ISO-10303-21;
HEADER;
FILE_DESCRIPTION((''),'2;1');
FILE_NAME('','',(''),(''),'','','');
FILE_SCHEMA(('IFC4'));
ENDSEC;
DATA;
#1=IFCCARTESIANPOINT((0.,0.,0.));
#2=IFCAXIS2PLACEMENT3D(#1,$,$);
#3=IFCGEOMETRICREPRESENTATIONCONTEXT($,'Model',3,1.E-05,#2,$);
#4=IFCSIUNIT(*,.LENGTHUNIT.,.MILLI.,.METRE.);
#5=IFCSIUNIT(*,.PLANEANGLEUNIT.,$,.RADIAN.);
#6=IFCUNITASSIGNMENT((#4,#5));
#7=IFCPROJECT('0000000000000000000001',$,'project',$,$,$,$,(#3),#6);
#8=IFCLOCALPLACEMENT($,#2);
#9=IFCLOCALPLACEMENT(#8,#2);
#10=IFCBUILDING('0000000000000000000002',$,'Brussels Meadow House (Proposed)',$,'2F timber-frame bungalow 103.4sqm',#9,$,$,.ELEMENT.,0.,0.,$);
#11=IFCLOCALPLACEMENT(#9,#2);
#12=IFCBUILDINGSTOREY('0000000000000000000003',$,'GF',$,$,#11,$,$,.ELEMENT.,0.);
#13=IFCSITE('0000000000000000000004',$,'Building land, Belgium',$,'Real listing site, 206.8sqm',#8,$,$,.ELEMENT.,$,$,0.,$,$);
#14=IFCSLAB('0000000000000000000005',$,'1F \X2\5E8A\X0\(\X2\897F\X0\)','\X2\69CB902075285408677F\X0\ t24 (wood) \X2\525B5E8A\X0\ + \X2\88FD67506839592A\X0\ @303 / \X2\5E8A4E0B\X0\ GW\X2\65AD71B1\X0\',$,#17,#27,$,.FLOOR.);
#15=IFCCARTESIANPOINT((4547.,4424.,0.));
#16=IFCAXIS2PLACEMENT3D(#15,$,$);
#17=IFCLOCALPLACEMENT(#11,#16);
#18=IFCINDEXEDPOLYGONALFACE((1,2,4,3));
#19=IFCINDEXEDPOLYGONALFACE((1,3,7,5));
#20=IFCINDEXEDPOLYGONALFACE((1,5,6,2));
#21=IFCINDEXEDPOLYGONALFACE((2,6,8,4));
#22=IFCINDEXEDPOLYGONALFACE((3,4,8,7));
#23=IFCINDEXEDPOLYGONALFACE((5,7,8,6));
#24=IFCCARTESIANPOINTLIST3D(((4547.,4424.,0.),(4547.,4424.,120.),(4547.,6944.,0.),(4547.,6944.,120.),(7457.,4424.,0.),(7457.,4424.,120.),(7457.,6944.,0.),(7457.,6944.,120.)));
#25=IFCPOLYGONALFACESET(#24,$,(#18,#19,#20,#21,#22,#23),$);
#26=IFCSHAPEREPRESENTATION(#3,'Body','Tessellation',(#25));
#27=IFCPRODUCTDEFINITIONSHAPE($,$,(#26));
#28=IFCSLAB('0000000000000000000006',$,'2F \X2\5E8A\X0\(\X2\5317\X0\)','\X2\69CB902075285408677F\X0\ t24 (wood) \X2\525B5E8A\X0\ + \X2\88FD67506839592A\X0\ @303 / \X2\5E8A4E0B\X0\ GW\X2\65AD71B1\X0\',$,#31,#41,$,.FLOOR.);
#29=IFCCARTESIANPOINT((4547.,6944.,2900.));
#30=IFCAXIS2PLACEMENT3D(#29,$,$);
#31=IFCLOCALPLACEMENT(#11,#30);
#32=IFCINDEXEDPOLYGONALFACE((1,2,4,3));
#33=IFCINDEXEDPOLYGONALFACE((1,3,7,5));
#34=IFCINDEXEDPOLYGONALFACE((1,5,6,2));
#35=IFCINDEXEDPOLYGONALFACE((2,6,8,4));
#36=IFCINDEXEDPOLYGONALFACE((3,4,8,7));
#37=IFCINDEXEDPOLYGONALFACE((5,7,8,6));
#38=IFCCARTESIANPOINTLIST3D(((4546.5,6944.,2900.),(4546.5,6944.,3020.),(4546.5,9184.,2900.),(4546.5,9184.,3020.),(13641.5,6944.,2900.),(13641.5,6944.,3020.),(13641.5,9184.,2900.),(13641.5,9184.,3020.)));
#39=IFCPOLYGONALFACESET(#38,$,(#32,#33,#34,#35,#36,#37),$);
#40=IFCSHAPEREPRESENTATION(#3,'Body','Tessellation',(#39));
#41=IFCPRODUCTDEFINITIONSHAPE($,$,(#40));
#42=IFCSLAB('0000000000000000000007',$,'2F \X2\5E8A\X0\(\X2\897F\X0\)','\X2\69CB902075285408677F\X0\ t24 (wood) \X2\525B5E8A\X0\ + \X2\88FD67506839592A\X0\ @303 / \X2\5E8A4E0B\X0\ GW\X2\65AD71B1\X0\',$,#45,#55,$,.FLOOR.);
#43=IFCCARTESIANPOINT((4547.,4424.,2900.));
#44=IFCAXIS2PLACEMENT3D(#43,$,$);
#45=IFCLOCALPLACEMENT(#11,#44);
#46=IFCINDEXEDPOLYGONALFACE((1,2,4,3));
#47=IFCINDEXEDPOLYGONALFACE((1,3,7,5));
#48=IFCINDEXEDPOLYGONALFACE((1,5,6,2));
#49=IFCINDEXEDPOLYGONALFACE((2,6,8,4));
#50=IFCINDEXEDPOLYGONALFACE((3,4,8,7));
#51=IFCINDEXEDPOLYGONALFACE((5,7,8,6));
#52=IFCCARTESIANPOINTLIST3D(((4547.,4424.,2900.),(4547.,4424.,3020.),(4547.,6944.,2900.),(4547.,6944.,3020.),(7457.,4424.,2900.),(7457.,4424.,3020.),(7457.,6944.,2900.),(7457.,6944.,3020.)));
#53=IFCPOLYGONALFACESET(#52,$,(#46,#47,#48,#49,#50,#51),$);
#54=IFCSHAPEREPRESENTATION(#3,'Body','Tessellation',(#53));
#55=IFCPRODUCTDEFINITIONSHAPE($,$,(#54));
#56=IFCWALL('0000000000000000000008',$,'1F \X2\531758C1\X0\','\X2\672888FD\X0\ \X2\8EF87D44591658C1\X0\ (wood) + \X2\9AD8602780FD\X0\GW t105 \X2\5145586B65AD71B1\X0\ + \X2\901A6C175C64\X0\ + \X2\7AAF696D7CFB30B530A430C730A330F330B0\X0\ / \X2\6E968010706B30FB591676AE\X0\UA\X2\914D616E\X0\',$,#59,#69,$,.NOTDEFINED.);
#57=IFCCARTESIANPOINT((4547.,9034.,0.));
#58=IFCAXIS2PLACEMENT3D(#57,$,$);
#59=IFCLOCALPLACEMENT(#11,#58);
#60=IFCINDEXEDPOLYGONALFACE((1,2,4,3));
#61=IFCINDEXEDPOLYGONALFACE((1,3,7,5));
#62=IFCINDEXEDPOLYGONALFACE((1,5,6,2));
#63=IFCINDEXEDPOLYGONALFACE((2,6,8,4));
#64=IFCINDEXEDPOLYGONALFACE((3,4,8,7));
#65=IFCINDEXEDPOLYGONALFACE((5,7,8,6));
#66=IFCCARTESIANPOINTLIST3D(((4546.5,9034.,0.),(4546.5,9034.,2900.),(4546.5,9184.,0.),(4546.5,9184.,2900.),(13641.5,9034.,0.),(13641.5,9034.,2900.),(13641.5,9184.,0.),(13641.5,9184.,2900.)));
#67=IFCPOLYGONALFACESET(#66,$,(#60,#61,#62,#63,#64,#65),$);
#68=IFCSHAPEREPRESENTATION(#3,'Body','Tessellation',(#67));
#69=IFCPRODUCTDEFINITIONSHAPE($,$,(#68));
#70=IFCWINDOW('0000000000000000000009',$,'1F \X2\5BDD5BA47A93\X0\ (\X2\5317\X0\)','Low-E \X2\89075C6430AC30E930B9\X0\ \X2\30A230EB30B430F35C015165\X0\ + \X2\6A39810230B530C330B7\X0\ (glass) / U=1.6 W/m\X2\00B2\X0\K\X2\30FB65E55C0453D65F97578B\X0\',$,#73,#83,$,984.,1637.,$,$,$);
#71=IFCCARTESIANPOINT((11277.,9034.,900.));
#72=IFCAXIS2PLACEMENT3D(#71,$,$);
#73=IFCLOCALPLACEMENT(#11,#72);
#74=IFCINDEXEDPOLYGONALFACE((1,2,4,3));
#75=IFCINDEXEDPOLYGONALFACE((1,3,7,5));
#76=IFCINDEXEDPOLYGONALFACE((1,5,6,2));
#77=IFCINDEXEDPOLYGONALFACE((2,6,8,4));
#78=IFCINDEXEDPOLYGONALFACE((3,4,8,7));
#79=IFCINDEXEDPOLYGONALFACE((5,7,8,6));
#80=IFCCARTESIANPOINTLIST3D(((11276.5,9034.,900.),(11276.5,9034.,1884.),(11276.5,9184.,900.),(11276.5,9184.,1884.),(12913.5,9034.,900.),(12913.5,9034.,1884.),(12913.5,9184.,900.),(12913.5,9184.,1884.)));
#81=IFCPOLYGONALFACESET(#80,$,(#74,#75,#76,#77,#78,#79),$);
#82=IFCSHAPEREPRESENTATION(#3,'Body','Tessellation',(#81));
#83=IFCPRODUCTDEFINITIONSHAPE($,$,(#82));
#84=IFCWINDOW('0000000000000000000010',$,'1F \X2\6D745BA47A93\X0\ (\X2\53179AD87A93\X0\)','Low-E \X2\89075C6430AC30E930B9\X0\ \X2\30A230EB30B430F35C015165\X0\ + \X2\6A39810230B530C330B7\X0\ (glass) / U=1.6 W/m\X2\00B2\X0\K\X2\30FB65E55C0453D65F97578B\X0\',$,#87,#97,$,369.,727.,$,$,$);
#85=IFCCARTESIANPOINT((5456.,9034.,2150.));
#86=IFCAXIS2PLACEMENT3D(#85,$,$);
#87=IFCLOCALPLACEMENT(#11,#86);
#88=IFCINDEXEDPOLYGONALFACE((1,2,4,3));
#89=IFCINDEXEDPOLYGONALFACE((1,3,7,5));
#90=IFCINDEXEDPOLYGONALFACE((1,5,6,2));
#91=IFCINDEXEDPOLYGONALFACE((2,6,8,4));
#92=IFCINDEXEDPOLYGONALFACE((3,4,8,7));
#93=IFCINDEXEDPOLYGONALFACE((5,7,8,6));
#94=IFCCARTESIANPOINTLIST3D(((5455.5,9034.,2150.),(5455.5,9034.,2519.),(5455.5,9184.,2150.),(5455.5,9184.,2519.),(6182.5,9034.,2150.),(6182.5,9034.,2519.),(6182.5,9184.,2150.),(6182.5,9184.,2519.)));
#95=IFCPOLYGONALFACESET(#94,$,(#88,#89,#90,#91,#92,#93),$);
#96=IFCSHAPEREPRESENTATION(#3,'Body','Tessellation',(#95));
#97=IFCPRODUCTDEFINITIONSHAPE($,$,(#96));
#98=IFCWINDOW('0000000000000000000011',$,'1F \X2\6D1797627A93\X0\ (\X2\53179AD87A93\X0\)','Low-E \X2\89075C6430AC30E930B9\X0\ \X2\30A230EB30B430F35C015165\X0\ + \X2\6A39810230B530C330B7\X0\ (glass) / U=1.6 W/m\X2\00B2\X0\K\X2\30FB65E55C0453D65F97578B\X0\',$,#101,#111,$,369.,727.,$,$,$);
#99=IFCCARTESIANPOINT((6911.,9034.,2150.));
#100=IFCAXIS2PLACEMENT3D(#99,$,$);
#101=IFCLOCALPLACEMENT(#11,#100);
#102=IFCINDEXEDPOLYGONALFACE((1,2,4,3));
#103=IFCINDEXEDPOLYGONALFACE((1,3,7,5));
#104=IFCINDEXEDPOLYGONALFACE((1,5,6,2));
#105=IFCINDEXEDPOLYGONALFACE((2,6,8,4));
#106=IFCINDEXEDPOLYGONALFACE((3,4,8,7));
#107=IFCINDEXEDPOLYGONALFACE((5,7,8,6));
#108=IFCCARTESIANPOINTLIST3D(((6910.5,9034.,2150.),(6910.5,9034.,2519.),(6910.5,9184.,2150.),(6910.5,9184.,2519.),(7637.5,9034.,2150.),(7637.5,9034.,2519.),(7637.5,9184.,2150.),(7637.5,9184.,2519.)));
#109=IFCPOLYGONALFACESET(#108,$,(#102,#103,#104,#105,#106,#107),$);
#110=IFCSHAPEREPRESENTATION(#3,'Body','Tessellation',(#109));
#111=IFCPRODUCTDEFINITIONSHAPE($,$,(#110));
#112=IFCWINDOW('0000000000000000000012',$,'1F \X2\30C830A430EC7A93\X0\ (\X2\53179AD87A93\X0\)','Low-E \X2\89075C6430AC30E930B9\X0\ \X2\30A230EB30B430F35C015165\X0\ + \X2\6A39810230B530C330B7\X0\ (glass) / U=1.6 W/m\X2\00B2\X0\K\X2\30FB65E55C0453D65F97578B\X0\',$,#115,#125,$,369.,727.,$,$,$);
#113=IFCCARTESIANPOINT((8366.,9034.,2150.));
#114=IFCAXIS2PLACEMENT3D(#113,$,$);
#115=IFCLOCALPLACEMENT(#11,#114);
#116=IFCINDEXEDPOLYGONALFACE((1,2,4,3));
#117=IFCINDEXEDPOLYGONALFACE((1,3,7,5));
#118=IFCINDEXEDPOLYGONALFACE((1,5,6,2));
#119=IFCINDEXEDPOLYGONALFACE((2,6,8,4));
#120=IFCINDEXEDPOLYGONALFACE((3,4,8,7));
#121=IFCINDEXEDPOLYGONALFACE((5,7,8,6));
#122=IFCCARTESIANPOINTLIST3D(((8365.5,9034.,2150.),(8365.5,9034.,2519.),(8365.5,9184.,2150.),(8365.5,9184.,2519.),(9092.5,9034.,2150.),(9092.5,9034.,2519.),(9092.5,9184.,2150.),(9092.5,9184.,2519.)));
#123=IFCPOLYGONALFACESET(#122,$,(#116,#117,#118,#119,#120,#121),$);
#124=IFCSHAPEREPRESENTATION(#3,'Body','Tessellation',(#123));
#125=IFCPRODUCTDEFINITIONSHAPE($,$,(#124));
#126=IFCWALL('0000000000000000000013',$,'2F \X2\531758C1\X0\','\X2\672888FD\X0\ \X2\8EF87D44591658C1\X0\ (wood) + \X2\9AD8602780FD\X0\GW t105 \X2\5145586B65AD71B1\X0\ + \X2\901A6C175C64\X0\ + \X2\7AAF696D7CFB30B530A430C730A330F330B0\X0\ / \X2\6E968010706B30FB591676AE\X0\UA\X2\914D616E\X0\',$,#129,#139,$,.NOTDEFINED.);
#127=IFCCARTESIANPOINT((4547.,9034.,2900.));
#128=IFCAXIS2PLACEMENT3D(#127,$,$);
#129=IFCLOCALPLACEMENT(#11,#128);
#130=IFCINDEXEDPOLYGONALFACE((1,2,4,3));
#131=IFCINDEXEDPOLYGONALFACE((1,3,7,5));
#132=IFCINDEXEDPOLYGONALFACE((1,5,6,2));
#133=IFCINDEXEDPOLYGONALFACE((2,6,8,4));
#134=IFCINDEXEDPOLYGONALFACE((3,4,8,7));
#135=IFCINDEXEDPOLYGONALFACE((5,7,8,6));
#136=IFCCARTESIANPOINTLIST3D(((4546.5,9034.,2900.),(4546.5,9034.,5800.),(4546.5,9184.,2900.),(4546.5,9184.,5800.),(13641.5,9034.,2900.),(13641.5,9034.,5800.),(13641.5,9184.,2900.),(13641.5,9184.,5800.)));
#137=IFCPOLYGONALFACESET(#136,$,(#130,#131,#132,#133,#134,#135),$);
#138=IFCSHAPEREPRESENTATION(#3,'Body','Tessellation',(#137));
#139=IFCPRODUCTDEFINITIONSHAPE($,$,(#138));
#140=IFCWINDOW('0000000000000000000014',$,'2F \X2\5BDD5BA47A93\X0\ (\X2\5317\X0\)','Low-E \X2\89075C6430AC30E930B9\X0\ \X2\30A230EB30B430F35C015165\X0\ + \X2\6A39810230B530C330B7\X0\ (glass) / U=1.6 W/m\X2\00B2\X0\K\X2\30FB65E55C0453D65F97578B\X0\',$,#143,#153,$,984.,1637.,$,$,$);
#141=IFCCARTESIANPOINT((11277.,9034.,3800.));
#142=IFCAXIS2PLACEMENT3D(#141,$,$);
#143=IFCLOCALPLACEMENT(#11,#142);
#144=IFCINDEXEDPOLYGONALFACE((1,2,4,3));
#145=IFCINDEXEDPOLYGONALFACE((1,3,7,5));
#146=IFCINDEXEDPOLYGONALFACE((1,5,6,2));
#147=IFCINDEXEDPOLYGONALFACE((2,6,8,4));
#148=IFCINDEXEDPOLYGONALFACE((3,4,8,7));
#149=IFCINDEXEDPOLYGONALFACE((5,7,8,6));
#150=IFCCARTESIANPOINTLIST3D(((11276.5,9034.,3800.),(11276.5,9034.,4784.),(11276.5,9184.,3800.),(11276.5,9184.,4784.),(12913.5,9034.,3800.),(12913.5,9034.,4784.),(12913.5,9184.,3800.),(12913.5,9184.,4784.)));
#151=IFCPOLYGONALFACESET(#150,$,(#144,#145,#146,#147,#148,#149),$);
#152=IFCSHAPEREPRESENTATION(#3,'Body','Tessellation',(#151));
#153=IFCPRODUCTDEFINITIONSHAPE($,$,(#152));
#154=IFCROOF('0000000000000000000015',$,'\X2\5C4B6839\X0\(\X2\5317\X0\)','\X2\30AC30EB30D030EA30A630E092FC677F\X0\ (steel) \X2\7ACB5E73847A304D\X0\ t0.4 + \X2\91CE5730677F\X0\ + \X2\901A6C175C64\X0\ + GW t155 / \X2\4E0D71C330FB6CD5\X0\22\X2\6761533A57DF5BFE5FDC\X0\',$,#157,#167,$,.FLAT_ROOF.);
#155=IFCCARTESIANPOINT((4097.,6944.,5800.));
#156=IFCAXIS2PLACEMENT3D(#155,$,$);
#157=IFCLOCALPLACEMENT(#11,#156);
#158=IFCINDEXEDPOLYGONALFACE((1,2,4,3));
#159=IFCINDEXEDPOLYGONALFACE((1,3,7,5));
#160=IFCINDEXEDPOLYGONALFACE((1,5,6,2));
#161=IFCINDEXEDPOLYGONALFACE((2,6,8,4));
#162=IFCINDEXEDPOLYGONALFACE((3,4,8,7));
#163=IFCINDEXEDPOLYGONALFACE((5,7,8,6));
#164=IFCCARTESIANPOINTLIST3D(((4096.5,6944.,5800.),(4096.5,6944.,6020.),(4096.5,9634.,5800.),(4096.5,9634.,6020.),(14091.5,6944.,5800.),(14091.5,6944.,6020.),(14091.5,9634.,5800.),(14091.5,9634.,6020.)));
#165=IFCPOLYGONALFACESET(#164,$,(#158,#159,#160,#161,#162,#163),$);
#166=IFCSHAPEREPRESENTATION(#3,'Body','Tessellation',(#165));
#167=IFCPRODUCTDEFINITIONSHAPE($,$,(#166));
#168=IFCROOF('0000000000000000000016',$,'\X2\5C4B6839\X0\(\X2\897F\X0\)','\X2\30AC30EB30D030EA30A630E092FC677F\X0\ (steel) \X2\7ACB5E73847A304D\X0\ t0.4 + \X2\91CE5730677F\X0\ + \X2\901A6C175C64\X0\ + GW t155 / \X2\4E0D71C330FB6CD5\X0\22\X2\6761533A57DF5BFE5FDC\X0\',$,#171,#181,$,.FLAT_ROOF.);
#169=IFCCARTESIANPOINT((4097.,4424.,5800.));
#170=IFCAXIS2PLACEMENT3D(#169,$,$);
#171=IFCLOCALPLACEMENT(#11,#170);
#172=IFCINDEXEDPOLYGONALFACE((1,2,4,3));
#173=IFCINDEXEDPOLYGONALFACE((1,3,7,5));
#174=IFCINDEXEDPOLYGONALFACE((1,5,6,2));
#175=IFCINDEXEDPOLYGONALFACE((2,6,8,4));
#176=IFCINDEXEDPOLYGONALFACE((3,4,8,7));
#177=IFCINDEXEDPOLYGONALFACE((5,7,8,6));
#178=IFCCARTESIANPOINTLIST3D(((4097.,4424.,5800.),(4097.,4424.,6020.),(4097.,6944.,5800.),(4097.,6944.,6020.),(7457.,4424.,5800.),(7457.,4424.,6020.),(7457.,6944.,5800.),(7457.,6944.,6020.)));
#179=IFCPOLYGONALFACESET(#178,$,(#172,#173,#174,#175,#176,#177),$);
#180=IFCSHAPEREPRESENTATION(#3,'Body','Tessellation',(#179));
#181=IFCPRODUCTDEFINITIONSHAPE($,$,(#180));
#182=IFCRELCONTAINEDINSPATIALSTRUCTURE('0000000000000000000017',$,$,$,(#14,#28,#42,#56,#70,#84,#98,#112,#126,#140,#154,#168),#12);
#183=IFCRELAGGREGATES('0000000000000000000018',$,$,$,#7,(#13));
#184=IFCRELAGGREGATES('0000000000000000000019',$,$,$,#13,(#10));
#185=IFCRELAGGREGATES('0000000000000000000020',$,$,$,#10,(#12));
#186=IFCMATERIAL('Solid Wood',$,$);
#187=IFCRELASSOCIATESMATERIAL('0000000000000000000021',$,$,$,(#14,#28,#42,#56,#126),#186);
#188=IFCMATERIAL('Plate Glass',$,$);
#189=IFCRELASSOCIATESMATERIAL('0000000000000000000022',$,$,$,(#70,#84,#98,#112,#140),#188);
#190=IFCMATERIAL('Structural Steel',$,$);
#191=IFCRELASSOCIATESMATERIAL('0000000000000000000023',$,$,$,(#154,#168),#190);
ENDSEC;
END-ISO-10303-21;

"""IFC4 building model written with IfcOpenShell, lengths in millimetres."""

from ifc_helpers import new_model, si_unit, frame, frame_2d, origin, place, context, project, spatial, rectangle, extrude, material, element, fill, save


model = new_model("IFC4")

# Units and contexts
model_context = context("Model", 3, precision=1e-05, world=origin())
ifc_project = project(units=[si_unit("LENGTHUNIT", "METRE", prefix="MILLI"), si_unit("PLANEANGLEUNIT", "RADIAN")], contexts=[model_context])

# Site, building, storey
site_placement = place(None, origin())
site = spatial("IfcSite", under=ifc_project, at=site_placement, Name="Building land, Belgium", ObjectType="Real listing site, 206.8sqm", CompositionType="ELEMENT", RefElevation=0.0)
building_placement = place(site_placement, origin())
building = spatial("IfcBuilding", under=site, at=building_placement, Name="Brussels Meadow House (Proposed)", ObjectType="2F timber-frame bungalow 103.4sqm", CompositionType="ELEMENT", ElevationOfRefHeight=0.0, ElevationOfTerrain=0.0)
storey_placement = place(building_placement, origin())
storey = spatial("IfcBuildingStorey", under=building, at=storey_placement, Name="GF", CompositionType="ELEMENT", Elevation=0.0)

# Slabs
ifc_material_1 = material(Name="Solid Wood")
slab_1_placement = place(storey_placement, frame((4547.0, 4424.0, 0.0)))
element("IfcSlab", 1, at=slab_1_placement, inside=storey, material=ifc_material_1, Name="1F 床(西)", Description="構造用合板 t24 (wood) 剛床 + 製材根太 @303 / 床下 GW断熱", PredefinedType="FLOOR", context=model_context, shape_type="SweptSolid", body=[
    extrude(rectangle(XDim=2910.0, YDim=2520.0, at=frame_2d((1455.0, 1260.0))), frame((4547.0, 4424.0, 0.0)), (0.0, 0.0, 1.0), 120.0),
])
slab_2_placement = place(storey_placement, frame((4547.0, 6944.0, 2900.0)))
element("IfcSlab", 2, at=slab_2_placement, inside=storey, material=ifc_material_1, Name="2F 床(北)", Description="構造用合板 t24 (wood) 剛床 + 製材根太 @303 / 床下 GW断熱", PredefinedType="FLOOR", context=model_context, shape_type="SweptSolid", body=[
    extrude(rectangle(XDim=9095.0, YDim=2240.0, at=frame_2d((4547.0, 1120.0))), frame((4547.0, 6944.0, 2900.0)), (0.0, 0.0, 1.0), 120.0),
])
slab_3_placement = place(storey_placement, frame((4547.0, 4424.0, 2900.0)))
element("IfcSlab", 3, at=slab_3_placement, inside=storey, material=ifc_material_1, Name="2F 床(西)", Description="構造用合板 t24 (wood) 剛床 + 製材根太 @303 / 床下 GW断熱", PredefinedType="FLOOR", context=model_context, shape_type="SweptSolid", body=[
    extrude(rectangle(XDim=2910.0, YDim=2520.0, at=frame_2d((1455.0, 1260.0))), frame((4547.0, 4424.0, 2900.0)), (0.0, 0.0, 1.0), 120.0),
])

# Wall, openings, windows
wall_1_placement = place(storey_placement, frame((4547.0, 9034.0, 0.0)))
wall_1 = element("IfcWall", 4, at=wall_1_placement, inside=storey, material=ifc_material_1, Name="1F 北壁", Description="木製 軸組外壁 (wood) + 高性能GW t105 充填断熱 + 通気層 + 窯業系サイディング / 準耐火・外皮UA配慮", PredefinedType="NOTDEFINED", context=model_context, shape_type="SweptSolid", body=[
    extrude(rectangle(XDim=9095.0, YDim=150.0, at=frame_2d((4547.0, 75.0))), frame((4547.0, 9034.0, 0.0)), (0.0, 0.0, 1.0), 2900.0),
])
opening_1_placement = place(storey_placement, frame((11277.0, 9034.0, 900.0)))
opening_1 = element("IfcOpeningElement", 5, at=opening_1_placement, cuts=wall_1, PredefinedType="NOTDEFINED", context=model_context, shape_type="SweptSolid", body=[
    extrude(rectangle(XDim=1637.0, YDim=150.0, at=frame_2d((818.0, 75.0))), frame((11277.0, 9034.0, 900.0)), (0.0, 0.0, 1.0), 984.0),
])
opening_2_placement = place(storey_placement, frame((5456.0, 9034.0, 2150.0)))
opening_2 = element("IfcOpeningElement", 6, at=opening_2_placement, cuts=wall_1, PredefinedType="NOTDEFINED", context=model_context, shape_type="SweptSolid", body=[
    extrude(rectangle(XDim=727.0, YDim=150.0, at=frame_2d((363.0, 75.0))), frame((5456.0, 9034.0, 2150.0)), (0.0, 0.0, 1.0), 369.0),
])
opening_3_placement = place(storey_placement, frame((6911.0, 9034.0, 2150.0)))
opening_3 = element("IfcOpeningElement", 7, at=opening_3_placement, cuts=wall_1, PredefinedType="NOTDEFINED", context=model_context, shape_type="SweptSolid", body=[
    extrude(rectangle(XDim=727.0, YDim=150.0, at=frame_2d((363.0, 75.0))), frame((6911.0, 9034.0, 2150.0)), (0.0, 0.0, 1.0), 369.0),
])
opening_4_placement = place(storey_placement, frame((8366.0, 9034.0, 2150.0)))
opening_4 = element("IfcOpeningElement", 8, at=opening_4_placement, cuts=wall_1, PredefinedType="NOTDEFINED", context=model_context, shape_type="SweptSolid", body=[
    extrude(rectangle(XDim=727.0, YDim=150.0, at=frame_2d((363.0, 75.0))), frame((8366.0, 9034.0, 2150.0)), (0.0, 0.0, 1.0), 369.0),
])
ifc_material_2 = material(Name="Plate Glass")
window_1_placement = place(storey_placement, frame((11277.0, 9034.0, 900.0)))
window_1 = element("IfcWindow", 9, at=window_1_placement, inside=storey, material=ifc_material_2, Name="1F 寝室窓 (北)", Description="Low-E 複層ガラス アルゴン封入 + 樹脂サッシ (glass) / U=1.6 W/m²K・日射取得型", OverallHeight=984.0, OverallWidth=1637.0, context=model_context, shape_type="SweptSolid", body=[
    extrude(rectangle(XDim=1637.0, YDim=150.0, at=frame_2d((818.0, 75.0))), frame((11277.0, 9034.0, 900.0)), (0.0, 0.0, 1.0), 984.0),
])
fill(opening_1, window_1)
window_2_placement = place(storey_placement, frame((5456.0, 9034.0, 2150.0)))
window_2 = element("IfcWindow", 10, at=window_2_placement, inside=storey, material=ifc_material_2, Name="1F 浴室窓 (北高窓)", Description="Low-E 複層ガラス アルゴン封入 + 樹脂サッシ (glass) / U=1.6 W/m²K・日射取得型", OverallHeight=369.0, OverallWidth=727.0, context=model_context, shape_type="SweptSolid", body=[
    extrude(rectangle(XDim=727.0, YDim=150.0, at=frame_2d((363.0, 75.0))), frame((5456.0, 9034.0, 2150.0)), (0.0, 0.0, 1.0), 369.0),
])
fill(opening_2, window_2)
window_3_placement = place(storey_placement, frame((6911.0, 9034.0, 2150.0)))
window_3 = element("IfcWindow", 11, at=window_3_placement, inside=storey, material=ifc_material_2, Name="1F 洗面窓 (北高窓)", Description="Low-E 複層ガラス アルゴン封入 + 樹脂サッシ (glass) / U=1.6 W/m²K・日射取得型", OverallHeight=369.0, OverallWidth=727.0, context=model_context, shape_type="SweptSolid", body=[
    extrude(rectangle(XDim=727.0, YDim=150.0, at=frame_2d((363.0, 75.0))), frame((6911.0, 9034.0, 2150.0)), (0.0, 0.0, 1.0), 369.0),
])
fill(opening_3, window_3)
window_4_placement = place(storey_placement, frame((8366.0, 9034.0, 2150.0)))
window_4 = element("IfcWindow", 12, at=window_4_placement, inside=storey, material=ifc_material_2, Name="1F トイレ窓 (北高窓)", Description="Low-E 複層ガラス アルゴン封入 + 樹脂サッシ (glass) / U=1.6 W/m²K・日射取得型", OverallHeight=369.0, OverallWidth=727.0, context=model_context, shape_type="SweptSolid", body=[
    extrude(rectangle(XDim=727.0, YDim=150.0, at=frame_2d((363.0, 75.0))), frame((8366.0, 9034.0, 2150.0)), (0.0, 0.0, 1.0), 369.0),
])
fill(opening_4, window_4)

# Wall, opening, window
wall_2_placement = place(storey_placement, frame((4547.0, 9034.0, 2900.0)))
wall_2 = element("IfcWall", 13, at=wall_2_placement, inside=storey, material=ifc_material_1, Name="2F 北壁", Description="木製 軸組外壁 (wood) + 高性能GW t105 充填断熱 + 通気層 + 窯業系サイディング / 準耐火・外皮UA配慮", PredefinedType="NOTDEFINED", context=model_context, shape_type="SweptSolid", body=[
    extrude(rectangle(XDim=9095.0, YDim=150.0, at=frame_2d((4547.0, 75.0))), frame((4547.0, 9034.0, 2900.0)), (0.0, 0.0, 1.0), 2900.0),
])
opening_5_placement = place(storey_placement, frame((11277.0, 9034.0, 3800.0)))
opening_5 = element("IfcOpeningElement", 14, at=opening_5_placement, cuts=wall_2, PredefinedType="NOTDEFINED", context=model_context, shape_type="SweptSolid", body=[
    extrude(rectangle(XDim=1637.0, YDim=150.0, at=frame_2d((818.0, 75.0))), frame((11277.0, 9034.0, 3800.0)), (0.0, 0.0, 1.0), 984.0),
])
window_5_placement = place(storey_placement, frame((11277.0, 9034.0, 3800.0)))
window_5 = element("IfcWindow", 15, at=window_5_placement, inside=storey, material=ifc_material_2, Name="2F 寝室窓 (北)", Description="Low-E 複層ガラス アルゴン封入 + 樹脂サッシ (glass) / U=1.6 W/m²K・日射取得型", OverallHeight=984.0, OverallWidth=1637.0, context=model_context, shape_type="SweptSolid", body=[
    extrude(rectangle(XDim=1637.0, YDim=150.0, at=frame_2d((818.0, 75.0))), frame((11277.0, 9034.0, 3800.0)), (0.0, 0.0, 1.0), 984.0),
])
fill(opening_5, window_5)

# Roofs
ifc_material_3 = material(Name="Structural Steel")
for number, where, name in (
    (16, (4097.0, 6944.0, 5800.0), "屋根(北)"),
):
    element("IfcRoof", number, at=place(storey_placement, frame(where)), inside=storey, material=ifc_material_3, Name=name, Description="ガルバリウム鋼板 (steel) 立平葺き t0.4 + 野地板 + 通気層 + GW t155 / 不燃・法22条区域対応", PredefinedType="FLAT_ROOF", context=model_context, shape_type="SweptSolid", body=[
        extrude(rectangle(XDim=9995.0, YDim=2690.0, at=frame_2d((4997.0, 1345.0))), frame((4097.0, 6944.0, 5800.0)), (0.0, 0.0, 1.0), 220.0),
    ])
roof_placement = place(storey_placement, frame((4097.0, 4424.0, 5800.0)))
element("IfcRoof", 17, at=roof_placement, inside=storey, material=ifc_material_3, Name="屋根(西)", Description="ガルバリウム鋼板 (steel) 立平葺き t0.4 + 野地板 + 通気層 + GW t155 / 不燃・法22条区域対応", PredefinedType="FLAT_ROOF", context=model_context, shape_type="SweptSolid", body=[
    extrude(rectangle(XDim=3360.0, YDim=2520.0, at=frame_2d((1680.0, 1260.0))), frame((4097.0, 4424.0, 5800.0)), (0.0, 0.0, 1.0), 220.0),
])

save(model, "model.ifc")
